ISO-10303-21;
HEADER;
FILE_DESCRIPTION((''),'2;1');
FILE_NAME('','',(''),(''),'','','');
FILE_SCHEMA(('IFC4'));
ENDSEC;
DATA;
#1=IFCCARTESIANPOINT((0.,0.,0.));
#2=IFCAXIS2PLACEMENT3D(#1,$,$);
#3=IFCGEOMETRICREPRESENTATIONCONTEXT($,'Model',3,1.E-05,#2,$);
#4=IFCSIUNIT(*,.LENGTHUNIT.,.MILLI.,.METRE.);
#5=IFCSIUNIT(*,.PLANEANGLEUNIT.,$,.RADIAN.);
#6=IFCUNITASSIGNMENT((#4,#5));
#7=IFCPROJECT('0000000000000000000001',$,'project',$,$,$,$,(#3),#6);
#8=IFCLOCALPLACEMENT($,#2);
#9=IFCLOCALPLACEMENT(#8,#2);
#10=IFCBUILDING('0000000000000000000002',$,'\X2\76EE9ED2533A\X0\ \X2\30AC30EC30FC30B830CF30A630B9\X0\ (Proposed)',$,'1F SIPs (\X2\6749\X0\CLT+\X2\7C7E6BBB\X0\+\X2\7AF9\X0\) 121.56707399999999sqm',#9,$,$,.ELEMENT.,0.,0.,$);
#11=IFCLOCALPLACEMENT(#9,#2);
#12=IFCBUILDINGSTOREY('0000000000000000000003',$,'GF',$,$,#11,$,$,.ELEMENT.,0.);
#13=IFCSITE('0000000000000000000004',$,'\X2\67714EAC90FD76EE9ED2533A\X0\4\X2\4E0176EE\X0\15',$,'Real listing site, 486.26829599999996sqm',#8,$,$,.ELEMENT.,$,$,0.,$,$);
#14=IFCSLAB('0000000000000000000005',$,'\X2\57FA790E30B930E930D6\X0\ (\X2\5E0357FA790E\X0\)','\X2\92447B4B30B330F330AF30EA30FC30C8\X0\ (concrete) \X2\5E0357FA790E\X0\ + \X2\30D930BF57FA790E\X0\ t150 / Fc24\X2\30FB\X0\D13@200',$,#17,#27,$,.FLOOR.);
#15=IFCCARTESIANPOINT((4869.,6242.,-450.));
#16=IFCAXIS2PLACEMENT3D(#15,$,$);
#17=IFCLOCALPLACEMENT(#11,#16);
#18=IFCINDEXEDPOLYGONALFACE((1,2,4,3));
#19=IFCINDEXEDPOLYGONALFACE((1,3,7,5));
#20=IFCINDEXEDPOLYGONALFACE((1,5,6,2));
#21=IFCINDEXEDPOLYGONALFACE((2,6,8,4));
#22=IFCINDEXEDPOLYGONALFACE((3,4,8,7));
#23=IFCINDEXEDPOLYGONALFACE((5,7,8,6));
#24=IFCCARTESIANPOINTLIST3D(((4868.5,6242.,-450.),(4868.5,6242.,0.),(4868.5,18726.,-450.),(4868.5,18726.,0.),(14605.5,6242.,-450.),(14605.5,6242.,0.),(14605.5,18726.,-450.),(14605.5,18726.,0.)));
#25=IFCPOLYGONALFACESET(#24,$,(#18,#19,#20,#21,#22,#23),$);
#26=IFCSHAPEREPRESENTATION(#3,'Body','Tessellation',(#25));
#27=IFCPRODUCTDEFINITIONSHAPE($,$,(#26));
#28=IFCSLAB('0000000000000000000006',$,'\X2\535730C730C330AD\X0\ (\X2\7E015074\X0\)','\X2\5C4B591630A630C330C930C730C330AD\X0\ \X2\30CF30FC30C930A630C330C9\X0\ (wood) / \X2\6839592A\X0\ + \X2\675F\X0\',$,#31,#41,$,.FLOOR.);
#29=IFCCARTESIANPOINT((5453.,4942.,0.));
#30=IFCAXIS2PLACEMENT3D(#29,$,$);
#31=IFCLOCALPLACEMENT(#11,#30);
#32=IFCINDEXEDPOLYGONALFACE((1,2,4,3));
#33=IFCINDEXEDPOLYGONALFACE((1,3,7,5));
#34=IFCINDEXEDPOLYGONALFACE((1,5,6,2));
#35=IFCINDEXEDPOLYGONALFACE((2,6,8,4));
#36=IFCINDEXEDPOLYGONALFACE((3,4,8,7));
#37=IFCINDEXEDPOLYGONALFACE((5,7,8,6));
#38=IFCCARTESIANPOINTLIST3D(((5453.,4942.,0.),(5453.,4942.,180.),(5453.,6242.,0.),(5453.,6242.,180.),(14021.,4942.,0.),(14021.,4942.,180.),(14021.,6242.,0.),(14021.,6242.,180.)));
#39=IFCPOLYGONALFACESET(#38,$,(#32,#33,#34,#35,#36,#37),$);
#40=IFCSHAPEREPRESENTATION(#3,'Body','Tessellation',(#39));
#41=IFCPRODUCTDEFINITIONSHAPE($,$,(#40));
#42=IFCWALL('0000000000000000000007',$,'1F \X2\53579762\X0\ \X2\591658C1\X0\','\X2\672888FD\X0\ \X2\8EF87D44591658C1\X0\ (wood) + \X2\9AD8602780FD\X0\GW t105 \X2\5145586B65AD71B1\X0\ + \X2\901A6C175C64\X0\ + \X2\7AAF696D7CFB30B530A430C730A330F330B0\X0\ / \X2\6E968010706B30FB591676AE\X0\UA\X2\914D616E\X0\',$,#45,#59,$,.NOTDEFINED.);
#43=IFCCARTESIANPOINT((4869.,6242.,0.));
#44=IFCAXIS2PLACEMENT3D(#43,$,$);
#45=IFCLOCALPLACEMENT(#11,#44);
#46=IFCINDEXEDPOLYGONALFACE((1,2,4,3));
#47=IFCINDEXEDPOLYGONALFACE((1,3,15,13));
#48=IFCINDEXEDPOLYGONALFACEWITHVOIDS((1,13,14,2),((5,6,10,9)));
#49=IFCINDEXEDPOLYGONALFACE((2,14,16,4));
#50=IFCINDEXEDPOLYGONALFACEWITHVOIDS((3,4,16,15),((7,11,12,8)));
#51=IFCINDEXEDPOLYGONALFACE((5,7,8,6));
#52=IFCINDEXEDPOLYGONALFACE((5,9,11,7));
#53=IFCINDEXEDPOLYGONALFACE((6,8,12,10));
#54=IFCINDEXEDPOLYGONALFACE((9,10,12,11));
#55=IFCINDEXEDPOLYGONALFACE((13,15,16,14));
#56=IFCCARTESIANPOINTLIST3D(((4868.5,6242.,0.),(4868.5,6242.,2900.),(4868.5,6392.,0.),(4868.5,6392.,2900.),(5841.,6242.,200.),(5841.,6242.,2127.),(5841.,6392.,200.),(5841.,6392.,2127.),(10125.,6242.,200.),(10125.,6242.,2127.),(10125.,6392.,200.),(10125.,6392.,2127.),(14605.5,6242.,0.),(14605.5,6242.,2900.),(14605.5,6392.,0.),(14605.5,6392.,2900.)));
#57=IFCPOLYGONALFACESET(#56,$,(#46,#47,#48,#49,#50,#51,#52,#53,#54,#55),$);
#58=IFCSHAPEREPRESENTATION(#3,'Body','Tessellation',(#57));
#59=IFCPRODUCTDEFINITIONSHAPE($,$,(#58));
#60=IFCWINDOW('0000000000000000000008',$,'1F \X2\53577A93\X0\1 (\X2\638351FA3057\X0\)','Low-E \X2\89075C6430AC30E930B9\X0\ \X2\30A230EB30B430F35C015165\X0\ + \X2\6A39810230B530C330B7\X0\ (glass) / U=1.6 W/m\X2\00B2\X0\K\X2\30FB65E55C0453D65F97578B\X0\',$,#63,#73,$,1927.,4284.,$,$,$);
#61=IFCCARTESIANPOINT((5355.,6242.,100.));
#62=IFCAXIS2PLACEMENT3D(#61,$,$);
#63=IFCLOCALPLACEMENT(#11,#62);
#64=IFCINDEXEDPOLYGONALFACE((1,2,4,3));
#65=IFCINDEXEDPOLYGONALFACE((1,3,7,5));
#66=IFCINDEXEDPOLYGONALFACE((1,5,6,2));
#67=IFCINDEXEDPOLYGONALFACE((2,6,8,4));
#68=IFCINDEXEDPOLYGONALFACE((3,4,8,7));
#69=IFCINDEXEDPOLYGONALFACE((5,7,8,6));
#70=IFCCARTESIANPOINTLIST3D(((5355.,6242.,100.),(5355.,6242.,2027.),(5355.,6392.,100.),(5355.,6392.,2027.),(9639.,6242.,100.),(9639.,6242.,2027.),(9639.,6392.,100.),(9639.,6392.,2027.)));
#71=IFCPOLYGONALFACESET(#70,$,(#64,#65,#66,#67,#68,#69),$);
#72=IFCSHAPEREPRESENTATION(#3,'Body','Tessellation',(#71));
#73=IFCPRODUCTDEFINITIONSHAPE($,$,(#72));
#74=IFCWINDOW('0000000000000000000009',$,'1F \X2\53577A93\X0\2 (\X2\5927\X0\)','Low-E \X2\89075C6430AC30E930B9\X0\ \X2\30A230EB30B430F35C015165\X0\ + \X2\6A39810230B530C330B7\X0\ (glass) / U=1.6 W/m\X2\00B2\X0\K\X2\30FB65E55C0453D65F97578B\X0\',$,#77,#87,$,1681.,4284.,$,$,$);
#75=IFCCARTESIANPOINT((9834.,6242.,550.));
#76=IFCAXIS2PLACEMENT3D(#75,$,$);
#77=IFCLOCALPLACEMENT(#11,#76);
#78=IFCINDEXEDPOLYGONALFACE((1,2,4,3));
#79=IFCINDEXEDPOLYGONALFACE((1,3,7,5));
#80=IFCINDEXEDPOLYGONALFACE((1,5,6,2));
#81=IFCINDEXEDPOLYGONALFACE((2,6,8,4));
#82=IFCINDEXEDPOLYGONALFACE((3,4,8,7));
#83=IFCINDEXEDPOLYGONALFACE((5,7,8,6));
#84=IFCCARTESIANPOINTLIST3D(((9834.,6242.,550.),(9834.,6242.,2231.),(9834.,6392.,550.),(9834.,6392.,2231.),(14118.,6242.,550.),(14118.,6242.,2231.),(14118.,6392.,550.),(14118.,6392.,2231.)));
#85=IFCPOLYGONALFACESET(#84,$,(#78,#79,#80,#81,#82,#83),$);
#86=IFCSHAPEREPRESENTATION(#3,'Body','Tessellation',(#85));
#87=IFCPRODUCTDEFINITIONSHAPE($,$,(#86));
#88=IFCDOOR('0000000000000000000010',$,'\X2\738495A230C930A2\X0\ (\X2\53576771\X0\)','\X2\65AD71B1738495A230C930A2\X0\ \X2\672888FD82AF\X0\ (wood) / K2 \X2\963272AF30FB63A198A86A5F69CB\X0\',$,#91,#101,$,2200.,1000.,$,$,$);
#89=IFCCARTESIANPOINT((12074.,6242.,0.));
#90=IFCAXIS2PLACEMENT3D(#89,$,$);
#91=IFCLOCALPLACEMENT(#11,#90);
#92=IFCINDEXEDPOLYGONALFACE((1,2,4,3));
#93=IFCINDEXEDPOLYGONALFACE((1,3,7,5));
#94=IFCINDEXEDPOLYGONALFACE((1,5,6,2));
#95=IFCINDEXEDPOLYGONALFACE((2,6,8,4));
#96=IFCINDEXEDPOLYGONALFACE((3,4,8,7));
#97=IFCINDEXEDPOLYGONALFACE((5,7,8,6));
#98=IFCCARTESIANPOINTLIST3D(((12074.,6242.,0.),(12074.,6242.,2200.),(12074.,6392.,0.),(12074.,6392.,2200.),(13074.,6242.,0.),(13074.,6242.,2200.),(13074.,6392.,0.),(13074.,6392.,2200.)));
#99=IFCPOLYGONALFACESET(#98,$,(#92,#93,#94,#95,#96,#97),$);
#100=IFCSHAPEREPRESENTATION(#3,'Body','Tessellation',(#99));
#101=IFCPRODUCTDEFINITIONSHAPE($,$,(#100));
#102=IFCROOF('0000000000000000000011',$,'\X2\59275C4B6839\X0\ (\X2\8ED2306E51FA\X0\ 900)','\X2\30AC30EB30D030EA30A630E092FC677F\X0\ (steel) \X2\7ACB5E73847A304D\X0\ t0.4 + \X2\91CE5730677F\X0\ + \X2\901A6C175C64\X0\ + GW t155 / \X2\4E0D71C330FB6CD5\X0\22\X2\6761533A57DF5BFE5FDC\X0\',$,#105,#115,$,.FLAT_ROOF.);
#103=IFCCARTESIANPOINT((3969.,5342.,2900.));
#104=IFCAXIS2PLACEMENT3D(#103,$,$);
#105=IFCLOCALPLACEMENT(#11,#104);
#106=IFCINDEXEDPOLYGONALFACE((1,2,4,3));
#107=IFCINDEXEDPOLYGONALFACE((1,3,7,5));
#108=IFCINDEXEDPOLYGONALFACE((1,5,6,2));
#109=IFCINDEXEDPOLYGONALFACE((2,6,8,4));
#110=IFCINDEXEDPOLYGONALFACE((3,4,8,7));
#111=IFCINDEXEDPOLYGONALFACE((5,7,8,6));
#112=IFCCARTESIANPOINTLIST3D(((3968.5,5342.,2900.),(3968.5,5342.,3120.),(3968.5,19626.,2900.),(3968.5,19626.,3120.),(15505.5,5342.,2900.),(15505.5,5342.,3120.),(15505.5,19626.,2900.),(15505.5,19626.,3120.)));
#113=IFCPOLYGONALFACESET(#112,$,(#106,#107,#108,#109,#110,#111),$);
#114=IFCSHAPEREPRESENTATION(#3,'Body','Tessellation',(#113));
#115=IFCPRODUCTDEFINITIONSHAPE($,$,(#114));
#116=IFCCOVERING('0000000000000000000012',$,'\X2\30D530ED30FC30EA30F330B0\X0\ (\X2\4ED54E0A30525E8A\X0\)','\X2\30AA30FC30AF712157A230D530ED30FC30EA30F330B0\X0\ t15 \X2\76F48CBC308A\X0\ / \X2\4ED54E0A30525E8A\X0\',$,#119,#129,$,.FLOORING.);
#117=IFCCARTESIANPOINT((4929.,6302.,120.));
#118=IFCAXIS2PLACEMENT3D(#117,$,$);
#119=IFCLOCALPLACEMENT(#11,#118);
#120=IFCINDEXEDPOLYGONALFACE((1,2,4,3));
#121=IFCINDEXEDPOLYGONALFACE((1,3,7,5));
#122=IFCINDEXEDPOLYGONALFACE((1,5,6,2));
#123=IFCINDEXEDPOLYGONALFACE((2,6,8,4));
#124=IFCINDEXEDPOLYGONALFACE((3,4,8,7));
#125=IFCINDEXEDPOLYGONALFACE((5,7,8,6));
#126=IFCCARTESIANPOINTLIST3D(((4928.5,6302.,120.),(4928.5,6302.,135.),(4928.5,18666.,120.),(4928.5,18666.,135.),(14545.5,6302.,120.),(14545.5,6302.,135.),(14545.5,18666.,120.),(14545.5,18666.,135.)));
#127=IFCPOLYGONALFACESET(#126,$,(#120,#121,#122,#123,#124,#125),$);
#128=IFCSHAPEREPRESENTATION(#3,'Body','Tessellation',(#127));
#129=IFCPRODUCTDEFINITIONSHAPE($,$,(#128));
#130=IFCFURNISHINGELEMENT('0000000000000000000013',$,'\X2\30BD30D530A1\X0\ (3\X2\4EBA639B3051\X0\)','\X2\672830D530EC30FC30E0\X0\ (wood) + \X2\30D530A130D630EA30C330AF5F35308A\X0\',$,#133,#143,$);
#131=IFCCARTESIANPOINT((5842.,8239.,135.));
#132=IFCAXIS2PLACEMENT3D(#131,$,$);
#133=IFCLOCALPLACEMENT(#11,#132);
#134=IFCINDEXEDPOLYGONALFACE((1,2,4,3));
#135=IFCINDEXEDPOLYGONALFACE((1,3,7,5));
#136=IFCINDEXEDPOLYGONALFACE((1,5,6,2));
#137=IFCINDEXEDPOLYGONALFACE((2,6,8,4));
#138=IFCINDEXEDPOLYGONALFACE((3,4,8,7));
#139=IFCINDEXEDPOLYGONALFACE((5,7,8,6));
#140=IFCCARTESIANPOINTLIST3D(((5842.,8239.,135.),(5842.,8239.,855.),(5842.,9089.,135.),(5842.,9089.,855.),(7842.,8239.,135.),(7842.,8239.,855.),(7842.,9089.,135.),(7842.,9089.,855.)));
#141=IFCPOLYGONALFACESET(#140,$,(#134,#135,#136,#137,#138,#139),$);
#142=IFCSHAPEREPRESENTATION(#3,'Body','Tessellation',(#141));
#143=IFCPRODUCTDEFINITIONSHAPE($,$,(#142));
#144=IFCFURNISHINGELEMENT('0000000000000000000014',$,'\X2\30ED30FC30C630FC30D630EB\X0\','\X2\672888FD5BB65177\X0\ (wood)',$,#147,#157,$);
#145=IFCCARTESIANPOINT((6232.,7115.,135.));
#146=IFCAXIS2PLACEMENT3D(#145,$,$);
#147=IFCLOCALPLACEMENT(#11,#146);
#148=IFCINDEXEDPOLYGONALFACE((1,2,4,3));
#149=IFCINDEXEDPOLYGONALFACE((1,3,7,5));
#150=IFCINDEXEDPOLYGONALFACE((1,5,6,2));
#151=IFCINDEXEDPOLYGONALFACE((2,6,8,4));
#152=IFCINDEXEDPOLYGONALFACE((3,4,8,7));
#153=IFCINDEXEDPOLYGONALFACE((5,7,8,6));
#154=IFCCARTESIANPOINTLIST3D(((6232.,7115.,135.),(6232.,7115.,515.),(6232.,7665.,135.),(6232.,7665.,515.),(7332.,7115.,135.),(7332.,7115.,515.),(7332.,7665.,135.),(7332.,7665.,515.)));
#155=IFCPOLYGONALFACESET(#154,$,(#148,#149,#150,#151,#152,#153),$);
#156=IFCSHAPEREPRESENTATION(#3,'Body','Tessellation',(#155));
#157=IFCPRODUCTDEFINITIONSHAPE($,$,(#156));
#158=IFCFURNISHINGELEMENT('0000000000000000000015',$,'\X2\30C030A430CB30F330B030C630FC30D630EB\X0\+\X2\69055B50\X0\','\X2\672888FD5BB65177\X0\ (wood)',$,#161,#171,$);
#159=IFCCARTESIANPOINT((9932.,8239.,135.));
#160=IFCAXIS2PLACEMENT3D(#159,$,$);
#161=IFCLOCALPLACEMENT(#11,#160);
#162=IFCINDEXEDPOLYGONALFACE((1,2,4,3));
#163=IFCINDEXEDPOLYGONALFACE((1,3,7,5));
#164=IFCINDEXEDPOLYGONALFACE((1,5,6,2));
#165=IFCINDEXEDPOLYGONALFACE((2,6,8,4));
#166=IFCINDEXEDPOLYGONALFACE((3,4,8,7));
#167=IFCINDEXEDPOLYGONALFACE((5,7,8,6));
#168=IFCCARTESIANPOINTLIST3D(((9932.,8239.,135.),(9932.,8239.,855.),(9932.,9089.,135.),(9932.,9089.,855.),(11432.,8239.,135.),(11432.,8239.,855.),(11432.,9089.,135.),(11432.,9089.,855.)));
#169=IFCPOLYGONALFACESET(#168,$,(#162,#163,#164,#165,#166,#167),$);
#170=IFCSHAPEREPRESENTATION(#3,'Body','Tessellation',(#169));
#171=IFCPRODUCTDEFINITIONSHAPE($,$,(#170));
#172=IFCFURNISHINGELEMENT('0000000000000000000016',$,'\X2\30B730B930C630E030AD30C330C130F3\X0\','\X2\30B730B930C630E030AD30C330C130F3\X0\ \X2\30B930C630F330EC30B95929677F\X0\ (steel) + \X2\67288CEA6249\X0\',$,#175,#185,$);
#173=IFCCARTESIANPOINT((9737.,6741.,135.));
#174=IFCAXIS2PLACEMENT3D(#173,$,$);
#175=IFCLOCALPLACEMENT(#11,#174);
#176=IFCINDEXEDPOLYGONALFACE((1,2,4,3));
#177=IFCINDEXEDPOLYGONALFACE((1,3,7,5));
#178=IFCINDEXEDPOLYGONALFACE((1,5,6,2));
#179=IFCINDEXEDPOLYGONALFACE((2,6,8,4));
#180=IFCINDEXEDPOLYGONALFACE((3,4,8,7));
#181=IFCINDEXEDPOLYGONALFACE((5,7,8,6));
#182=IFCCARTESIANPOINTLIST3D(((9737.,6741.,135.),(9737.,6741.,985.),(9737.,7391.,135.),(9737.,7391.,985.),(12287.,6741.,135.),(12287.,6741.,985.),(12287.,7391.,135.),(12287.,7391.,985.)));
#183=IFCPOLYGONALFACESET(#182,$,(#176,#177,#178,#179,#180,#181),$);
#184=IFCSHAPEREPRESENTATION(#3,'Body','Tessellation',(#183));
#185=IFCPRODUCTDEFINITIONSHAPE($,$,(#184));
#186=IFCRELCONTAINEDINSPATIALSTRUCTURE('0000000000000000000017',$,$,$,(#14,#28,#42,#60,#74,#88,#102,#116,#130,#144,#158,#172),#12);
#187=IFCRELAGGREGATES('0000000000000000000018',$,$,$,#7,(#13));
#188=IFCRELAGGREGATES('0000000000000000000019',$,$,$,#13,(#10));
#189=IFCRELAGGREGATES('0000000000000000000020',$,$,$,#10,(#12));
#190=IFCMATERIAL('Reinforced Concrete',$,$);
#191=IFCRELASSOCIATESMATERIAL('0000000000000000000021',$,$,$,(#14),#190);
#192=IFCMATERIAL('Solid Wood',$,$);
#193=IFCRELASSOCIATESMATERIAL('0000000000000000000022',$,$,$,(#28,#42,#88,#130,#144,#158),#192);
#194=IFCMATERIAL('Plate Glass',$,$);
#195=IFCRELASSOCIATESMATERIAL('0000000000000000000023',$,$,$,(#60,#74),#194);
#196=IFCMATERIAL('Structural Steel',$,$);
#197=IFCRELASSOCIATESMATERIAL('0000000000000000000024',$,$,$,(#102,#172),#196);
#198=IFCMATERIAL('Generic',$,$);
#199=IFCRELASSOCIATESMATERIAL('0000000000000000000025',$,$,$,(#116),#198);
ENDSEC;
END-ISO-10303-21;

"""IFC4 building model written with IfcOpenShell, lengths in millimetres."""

from ifc_helpers import new_model, si_unit, frame, frame_2d, origin, place, context, project, spatial, rectangle, extrude, material, element, fill, save


model = new_model("IFC4")

# Units and contexts
model_context = context("Model", 3, precision=1e-05, world=origin())
ifc_project = project(units=[si_unit("LENGTHUNIT", "METRE", prefix="MILLI"), si_unit("PLANEANGLEUNIT", "RADIAN")], contexts=[model_context])

# Site, building, storey
site_placement = place(None, origin())
site = spatial("IfcSite", under=ifc_project, at=site_placement, Name="東京都目黒区4丁目15", ObjectType="Real listing site, 486.26829599999996sqm", CompositionType="ELEMENT", RefElevation=0.0)
building_placement = place(site_placement, origin())
building = spatial("IfcBuilding", under=site, at=building_placement, Name="目黒区 ガレージハウス (Proposed)", ObjectType="1F SIPs (杉CLT+籾殻+竹) 121.56707399999999sqm", CompositionType="ELEMENT", ElevationOfRefHeight=0.0, ElevationOfTerrain=0.0)
storey_placement = place(building_placement, origin())
storey = spatial("IfcBuildingStorey", under=building, at=storey_placement, Name="GF", CompositionType="ELEMENT", Elevation=0.0)

# Slabs
ifc_material_1 = material(Name="Reinforced Concrete")
slab_1_placement = place(storey_placement, frame((4869.0, 6242.0, -450.0)))
element("IfcSlab", 1, at=slab_1_placement, inside=storey, material=ifc_material_1, Name="基礎スラブ (布基礎)", Description="鉄筋コンクリート (concrete) 布基礎 + ベタ基礎 t150 / Fc24・D13@200", PredefinedType="FLOOR", context=model_context, shape_type="SweptSolid", body=[
    extrude(rectangle(XDim=9737.0, YDim=12484.0, at=frame_2d((4868.0, 6242.0))), frame((4869.0, 6242.0, -450.0)), (0.0, 0.0, 1.0), 450.0),
])
ifc_material_2 = material(Name="Solid Wood")
slab_2_placement = place(storey_placement, frame((5453.0, 4942.0, 0.0)))
element("IfcSlab", 2, at=slab_2_placement, inside=storey, material=ifc_material_2, Name="南デッキ (縁側)", Description="屋外ウッドデッキ ハードウッド (wood) / 根太 + 束", PredefinedType="FLOOR", context=model_context, shape_type="SweptSolid", body=[
    extrude(rectangle(XDim=8568.0, YDim=1300.0, at=frame_2d((4284.0, 650.0))), frame((5453.0, 4942.0, 0.0)), (0.0, 0.0, 1.0), 180.0),
])

# Wall, openings, windows, door
wall_1_placement = place(storey_placement, frame((4869.0, 6242.0, 0.0)))
wall_1 = element("IfcWall", 3, at=wall_1_placement, inside=storey, material=ifc_material_2, Name="1F 南面 外壁", Description="木製 軸組外壁 (wood) + 高性能GW t105 充填断熱 + 通気層 + 窯業系サイディング / 準耐火・外皮UA配慮", PredefinedType="NOTDEFINED", context=model_context, shape_type="SweptSolid", body=[
    extrude(rectangle(XDim=9737.0, YDim=150.0, at=frame_2d((4868.0, 75.0))), frame((4869.0, 6242.0, 0.0)), (0.0, 0.0, 1.0), 2900.0),
])
opening_1_placement = place(storey_placement, frame((5355.0, 6242.0, 100.0)))
opening_1 = element("IfcOpeningElement", 4, at=opening_1_placement, cuts=wall_1, PredefinedType="NOTDEFINED", context=model_context, shape_type="SweptSolid", body=[
    extrude(rectangle(XDim=4284.0, YDim=150.0, at=frame_2d((2142.0, 75.0))), frame((5355.0, 6242.0, 100.0)), (0.0, 0.0, 1.0), 1927.0),
])
opening_2_placement = place(storey_placement, frame((9834.0, 6242.0, 550.0)))
opening_2 = element("IfcOpeningElement", 5, at=opening_2_placement, cuts=wall_1, PredefinedType="NOTDEFINED", context=model_context, shape_type="SweptSolid", body=[
    extrude(rectangle(XDim=4284.0, YDim=150.0, at=frame_2d((2142.0, 75.0))), frame((9834.0, 6242.0, 550.0)), (0.0, 0.0, 1.0), 1681.0),
])
opening_3_placement = place(storey_placement, frame((12074.0, 6242.0, 0.0)))
opening_3 = element("IfcOpeningElement", 6, at=opening_3_placement, cuts=wall_1, PredefinedType="NOTDEFINED", context=model_context, shape_type="SweptSolid", body=[
    extrude(rectangle(XDim=1000.0, YDim=150.0, at=frame_2d((500.0, 75.0))), frame((12074.0, 6242.0, 0.0)), (0.0, 0.0, 1.0), 2200.0),
])
ifc_material_3 = material(Name="Plate Glass")
window_1_placement = place(storey_placement, frame((5355.0, 6242.0, 100.0)))
window_1 = element("IfcWindow", 7, at=window_1_placement, inside=storey, material=ifc_material_3, Name="1F 南窓1 (掃出し)", Description="Low-E 複層ガラス アルゴン封入 + 樹脂サッシ (glass) / U=1.6 W/m²K・日射取得型", OverallHeight=1927.0, OverallWidth=4284.0, context=model_context, shape_type="SweptSolid", body=[
    extrude(rectangle(XDim=4284.0, YDim=150.0, at=frame_2d((2142.0, 75.0))), frame((5355.0, 6242.0, 100.0)), (0.0, 0.0, 1.0), 1927.0),
])
fill(opening_1, window_1)
window_2_placement = place(storey_placement, frame((9834.0, 6242.0, 550.0)))
window_2 = element("IfcWindow", 8, at=window_2_placement, inside=storey, material=ifc_material_3, Name="1F 南窓2 (大)", Description="Low-E 複層ガラス アルゴン封入 + 樹脂サッシ (glass) / U=1.6 W/m²K・日射取得型", OverallHeight=1681.0, OverallWidth=4284.0, context=model_context, shape_type="SweptSolid", body=[
    extrude(rectangle(XDim=4284.0, YDim=150.0, at=frame_2d((2142.0, 75.0))), frame((9834.0, 6242.0, 550.0)), (0.0, 0.0, 1.0), 1681.0),
])
fill(opening_2, window_2)
door_placement = place(storey_placement, frame((12074.0, 6242.0, 0.0)))
door = element("IfcDoor", 9, at=door_placement, inside=storey, material=ifc_material_2, Name="玄関ドア (南東)", Description="断熱玄関ドア 木製芯 (wood) / K2 防犯・採風機構", OverallHeight=2200.0, OverallWidth=1000.0, context=model_context, shape_type="SweptSolid", body=[
    extrude(rectangle(XDim=1000.0, YDim=150.0, at=frame_2d((500.0, 75.0))), frame((12074.0, 6242.0, 0.0)), (0.0, 0.0, 1.0), 2200.0),
])
fill(opening_3, door)

# Roof
ifc_material_4 = material(Name="Structural Steel")
roof_placement = place(storey_placement, frame((3969.0, 5342.0, 2900.0)))
element("IfcRoof", 10, at=roof_placement, inside=storey, material=ifc_material_4, Name="大屋根 (軒の出 900)", Description="ガルバリウム鋼板 (steel) 立平葺き t0.4 + 野地板 + 通気層 + GW t155 / 不燃・法22条区域対応", PredefinedType="FLAT_ROOF", context=model_context, shape_type="SweptSolid", body=[
    extrude(rectangle(XDim=11537.0, YDim=14284.0, at=frame_2d((5768.0, 7142.0))), frame((3969.0, 5342.0, 2900.0)), (0.0, 0.0, 1.0), 220.0),
])

# Covering
ifc_material_5 = material(Name="Generic")
covering_placement = place(storey_placement, frame((4929.0, 6302.0, 120.0)))
element("IfcCovering", 11, at=covering_placement, inside=storey, material=ifc_material_5, Name="フローリング (仕上げ床)", Description="オーク無垢フローリング t15 直貼り / 仕上げ床", PredefinedType="FLOORING", context=model_context, shape_type="SweptSolid", body=[
    extrude(rectangle(XDim=9617.0, YDim=12364.0, at=frame_2d((4808.0, 6182.0))), frame((4929.0, 6302.0, 120.0)), (0.0, 0.0, 1.0), 15.0),
])

# Furnishing elements
furnishing_1_placement = place(storey_placement, frame((5842.0, 8239.0, 135.0)))
element("IfcFurnishingElement", 12, at=furnishing_1_placement, inside=storey, material=ifc_material_2, Name="ソファ (3人掛け)", Description="木フレーム (wood) + ファブリック張り", context=model_context, shape_type="SweptSolid", body=[
    extrude(rectangle(XDim=2000.0, YDim=850.0, at=frame_2d((1000.0, 425.0))), frame((5842.0, 8239.0, 135.0)), (0.0, 0.0, 1.0), 720.0),
])
furnishing_2_placement = place(storey_placement, frame((6232.0, 7115.0, 135.0)))
element("IfcFurnishingElement", 13, at=furnishing_2_placement, inside=storey, material=ifc_material_2, Name="ローテーブル", Description="木製家具 (wood)", context=model_context, shape_type="SweptSolid", body=[
    extrude(rectangle(XDim=1100.0, YDim=550.0, at=frame_2d((550.0, 275.0))), frame((6232.0, 7115.0, 135.0)), (0.0, 0.0, 1.0), 380.0),
])
furnishing_3_placement = place(storey_placement, frame((9932.0, 8239.0, 135.0)))
element("IfcFurnishingElement", 14, at=furnishing_3_placement, inside=storey, material=ifc_material_2, Name="ダイニングテーブル+椅子", Description="木製家具 (wood)", context=model_context, shape_type="SweptSolid", body=[
    extrude(rectangle(XDim=1500.0, YDim=850.0, at=frame_2d((750.0, 425.0))), frame((9932.0, 8239.0, 135.0)), (0.0, 0.0, 1.0), 720.0),
])
furnishing_4_placement = place(storey_placement, frame((9737.0, 6741.0, 135.0)))
element("IfcFurnishingElement", 15, at=furnishing_4_placement, inside=storey, material=ifc_material_4, Name="システムキッチン", Description="システムキッチン ステンレス天板 (steel) + 木質扉", context=model_context, shape_type="SweptSolid", body=[
    extrude(rectangle(XDim=2550.0, YDim=650.0, at=frame_2d((1275.0, 325.0))), frame((9737.0, 6741.0, 135.0)), (0.0, 0.0, 1.0), 850.0),
])

save(model, "model.ifc")
